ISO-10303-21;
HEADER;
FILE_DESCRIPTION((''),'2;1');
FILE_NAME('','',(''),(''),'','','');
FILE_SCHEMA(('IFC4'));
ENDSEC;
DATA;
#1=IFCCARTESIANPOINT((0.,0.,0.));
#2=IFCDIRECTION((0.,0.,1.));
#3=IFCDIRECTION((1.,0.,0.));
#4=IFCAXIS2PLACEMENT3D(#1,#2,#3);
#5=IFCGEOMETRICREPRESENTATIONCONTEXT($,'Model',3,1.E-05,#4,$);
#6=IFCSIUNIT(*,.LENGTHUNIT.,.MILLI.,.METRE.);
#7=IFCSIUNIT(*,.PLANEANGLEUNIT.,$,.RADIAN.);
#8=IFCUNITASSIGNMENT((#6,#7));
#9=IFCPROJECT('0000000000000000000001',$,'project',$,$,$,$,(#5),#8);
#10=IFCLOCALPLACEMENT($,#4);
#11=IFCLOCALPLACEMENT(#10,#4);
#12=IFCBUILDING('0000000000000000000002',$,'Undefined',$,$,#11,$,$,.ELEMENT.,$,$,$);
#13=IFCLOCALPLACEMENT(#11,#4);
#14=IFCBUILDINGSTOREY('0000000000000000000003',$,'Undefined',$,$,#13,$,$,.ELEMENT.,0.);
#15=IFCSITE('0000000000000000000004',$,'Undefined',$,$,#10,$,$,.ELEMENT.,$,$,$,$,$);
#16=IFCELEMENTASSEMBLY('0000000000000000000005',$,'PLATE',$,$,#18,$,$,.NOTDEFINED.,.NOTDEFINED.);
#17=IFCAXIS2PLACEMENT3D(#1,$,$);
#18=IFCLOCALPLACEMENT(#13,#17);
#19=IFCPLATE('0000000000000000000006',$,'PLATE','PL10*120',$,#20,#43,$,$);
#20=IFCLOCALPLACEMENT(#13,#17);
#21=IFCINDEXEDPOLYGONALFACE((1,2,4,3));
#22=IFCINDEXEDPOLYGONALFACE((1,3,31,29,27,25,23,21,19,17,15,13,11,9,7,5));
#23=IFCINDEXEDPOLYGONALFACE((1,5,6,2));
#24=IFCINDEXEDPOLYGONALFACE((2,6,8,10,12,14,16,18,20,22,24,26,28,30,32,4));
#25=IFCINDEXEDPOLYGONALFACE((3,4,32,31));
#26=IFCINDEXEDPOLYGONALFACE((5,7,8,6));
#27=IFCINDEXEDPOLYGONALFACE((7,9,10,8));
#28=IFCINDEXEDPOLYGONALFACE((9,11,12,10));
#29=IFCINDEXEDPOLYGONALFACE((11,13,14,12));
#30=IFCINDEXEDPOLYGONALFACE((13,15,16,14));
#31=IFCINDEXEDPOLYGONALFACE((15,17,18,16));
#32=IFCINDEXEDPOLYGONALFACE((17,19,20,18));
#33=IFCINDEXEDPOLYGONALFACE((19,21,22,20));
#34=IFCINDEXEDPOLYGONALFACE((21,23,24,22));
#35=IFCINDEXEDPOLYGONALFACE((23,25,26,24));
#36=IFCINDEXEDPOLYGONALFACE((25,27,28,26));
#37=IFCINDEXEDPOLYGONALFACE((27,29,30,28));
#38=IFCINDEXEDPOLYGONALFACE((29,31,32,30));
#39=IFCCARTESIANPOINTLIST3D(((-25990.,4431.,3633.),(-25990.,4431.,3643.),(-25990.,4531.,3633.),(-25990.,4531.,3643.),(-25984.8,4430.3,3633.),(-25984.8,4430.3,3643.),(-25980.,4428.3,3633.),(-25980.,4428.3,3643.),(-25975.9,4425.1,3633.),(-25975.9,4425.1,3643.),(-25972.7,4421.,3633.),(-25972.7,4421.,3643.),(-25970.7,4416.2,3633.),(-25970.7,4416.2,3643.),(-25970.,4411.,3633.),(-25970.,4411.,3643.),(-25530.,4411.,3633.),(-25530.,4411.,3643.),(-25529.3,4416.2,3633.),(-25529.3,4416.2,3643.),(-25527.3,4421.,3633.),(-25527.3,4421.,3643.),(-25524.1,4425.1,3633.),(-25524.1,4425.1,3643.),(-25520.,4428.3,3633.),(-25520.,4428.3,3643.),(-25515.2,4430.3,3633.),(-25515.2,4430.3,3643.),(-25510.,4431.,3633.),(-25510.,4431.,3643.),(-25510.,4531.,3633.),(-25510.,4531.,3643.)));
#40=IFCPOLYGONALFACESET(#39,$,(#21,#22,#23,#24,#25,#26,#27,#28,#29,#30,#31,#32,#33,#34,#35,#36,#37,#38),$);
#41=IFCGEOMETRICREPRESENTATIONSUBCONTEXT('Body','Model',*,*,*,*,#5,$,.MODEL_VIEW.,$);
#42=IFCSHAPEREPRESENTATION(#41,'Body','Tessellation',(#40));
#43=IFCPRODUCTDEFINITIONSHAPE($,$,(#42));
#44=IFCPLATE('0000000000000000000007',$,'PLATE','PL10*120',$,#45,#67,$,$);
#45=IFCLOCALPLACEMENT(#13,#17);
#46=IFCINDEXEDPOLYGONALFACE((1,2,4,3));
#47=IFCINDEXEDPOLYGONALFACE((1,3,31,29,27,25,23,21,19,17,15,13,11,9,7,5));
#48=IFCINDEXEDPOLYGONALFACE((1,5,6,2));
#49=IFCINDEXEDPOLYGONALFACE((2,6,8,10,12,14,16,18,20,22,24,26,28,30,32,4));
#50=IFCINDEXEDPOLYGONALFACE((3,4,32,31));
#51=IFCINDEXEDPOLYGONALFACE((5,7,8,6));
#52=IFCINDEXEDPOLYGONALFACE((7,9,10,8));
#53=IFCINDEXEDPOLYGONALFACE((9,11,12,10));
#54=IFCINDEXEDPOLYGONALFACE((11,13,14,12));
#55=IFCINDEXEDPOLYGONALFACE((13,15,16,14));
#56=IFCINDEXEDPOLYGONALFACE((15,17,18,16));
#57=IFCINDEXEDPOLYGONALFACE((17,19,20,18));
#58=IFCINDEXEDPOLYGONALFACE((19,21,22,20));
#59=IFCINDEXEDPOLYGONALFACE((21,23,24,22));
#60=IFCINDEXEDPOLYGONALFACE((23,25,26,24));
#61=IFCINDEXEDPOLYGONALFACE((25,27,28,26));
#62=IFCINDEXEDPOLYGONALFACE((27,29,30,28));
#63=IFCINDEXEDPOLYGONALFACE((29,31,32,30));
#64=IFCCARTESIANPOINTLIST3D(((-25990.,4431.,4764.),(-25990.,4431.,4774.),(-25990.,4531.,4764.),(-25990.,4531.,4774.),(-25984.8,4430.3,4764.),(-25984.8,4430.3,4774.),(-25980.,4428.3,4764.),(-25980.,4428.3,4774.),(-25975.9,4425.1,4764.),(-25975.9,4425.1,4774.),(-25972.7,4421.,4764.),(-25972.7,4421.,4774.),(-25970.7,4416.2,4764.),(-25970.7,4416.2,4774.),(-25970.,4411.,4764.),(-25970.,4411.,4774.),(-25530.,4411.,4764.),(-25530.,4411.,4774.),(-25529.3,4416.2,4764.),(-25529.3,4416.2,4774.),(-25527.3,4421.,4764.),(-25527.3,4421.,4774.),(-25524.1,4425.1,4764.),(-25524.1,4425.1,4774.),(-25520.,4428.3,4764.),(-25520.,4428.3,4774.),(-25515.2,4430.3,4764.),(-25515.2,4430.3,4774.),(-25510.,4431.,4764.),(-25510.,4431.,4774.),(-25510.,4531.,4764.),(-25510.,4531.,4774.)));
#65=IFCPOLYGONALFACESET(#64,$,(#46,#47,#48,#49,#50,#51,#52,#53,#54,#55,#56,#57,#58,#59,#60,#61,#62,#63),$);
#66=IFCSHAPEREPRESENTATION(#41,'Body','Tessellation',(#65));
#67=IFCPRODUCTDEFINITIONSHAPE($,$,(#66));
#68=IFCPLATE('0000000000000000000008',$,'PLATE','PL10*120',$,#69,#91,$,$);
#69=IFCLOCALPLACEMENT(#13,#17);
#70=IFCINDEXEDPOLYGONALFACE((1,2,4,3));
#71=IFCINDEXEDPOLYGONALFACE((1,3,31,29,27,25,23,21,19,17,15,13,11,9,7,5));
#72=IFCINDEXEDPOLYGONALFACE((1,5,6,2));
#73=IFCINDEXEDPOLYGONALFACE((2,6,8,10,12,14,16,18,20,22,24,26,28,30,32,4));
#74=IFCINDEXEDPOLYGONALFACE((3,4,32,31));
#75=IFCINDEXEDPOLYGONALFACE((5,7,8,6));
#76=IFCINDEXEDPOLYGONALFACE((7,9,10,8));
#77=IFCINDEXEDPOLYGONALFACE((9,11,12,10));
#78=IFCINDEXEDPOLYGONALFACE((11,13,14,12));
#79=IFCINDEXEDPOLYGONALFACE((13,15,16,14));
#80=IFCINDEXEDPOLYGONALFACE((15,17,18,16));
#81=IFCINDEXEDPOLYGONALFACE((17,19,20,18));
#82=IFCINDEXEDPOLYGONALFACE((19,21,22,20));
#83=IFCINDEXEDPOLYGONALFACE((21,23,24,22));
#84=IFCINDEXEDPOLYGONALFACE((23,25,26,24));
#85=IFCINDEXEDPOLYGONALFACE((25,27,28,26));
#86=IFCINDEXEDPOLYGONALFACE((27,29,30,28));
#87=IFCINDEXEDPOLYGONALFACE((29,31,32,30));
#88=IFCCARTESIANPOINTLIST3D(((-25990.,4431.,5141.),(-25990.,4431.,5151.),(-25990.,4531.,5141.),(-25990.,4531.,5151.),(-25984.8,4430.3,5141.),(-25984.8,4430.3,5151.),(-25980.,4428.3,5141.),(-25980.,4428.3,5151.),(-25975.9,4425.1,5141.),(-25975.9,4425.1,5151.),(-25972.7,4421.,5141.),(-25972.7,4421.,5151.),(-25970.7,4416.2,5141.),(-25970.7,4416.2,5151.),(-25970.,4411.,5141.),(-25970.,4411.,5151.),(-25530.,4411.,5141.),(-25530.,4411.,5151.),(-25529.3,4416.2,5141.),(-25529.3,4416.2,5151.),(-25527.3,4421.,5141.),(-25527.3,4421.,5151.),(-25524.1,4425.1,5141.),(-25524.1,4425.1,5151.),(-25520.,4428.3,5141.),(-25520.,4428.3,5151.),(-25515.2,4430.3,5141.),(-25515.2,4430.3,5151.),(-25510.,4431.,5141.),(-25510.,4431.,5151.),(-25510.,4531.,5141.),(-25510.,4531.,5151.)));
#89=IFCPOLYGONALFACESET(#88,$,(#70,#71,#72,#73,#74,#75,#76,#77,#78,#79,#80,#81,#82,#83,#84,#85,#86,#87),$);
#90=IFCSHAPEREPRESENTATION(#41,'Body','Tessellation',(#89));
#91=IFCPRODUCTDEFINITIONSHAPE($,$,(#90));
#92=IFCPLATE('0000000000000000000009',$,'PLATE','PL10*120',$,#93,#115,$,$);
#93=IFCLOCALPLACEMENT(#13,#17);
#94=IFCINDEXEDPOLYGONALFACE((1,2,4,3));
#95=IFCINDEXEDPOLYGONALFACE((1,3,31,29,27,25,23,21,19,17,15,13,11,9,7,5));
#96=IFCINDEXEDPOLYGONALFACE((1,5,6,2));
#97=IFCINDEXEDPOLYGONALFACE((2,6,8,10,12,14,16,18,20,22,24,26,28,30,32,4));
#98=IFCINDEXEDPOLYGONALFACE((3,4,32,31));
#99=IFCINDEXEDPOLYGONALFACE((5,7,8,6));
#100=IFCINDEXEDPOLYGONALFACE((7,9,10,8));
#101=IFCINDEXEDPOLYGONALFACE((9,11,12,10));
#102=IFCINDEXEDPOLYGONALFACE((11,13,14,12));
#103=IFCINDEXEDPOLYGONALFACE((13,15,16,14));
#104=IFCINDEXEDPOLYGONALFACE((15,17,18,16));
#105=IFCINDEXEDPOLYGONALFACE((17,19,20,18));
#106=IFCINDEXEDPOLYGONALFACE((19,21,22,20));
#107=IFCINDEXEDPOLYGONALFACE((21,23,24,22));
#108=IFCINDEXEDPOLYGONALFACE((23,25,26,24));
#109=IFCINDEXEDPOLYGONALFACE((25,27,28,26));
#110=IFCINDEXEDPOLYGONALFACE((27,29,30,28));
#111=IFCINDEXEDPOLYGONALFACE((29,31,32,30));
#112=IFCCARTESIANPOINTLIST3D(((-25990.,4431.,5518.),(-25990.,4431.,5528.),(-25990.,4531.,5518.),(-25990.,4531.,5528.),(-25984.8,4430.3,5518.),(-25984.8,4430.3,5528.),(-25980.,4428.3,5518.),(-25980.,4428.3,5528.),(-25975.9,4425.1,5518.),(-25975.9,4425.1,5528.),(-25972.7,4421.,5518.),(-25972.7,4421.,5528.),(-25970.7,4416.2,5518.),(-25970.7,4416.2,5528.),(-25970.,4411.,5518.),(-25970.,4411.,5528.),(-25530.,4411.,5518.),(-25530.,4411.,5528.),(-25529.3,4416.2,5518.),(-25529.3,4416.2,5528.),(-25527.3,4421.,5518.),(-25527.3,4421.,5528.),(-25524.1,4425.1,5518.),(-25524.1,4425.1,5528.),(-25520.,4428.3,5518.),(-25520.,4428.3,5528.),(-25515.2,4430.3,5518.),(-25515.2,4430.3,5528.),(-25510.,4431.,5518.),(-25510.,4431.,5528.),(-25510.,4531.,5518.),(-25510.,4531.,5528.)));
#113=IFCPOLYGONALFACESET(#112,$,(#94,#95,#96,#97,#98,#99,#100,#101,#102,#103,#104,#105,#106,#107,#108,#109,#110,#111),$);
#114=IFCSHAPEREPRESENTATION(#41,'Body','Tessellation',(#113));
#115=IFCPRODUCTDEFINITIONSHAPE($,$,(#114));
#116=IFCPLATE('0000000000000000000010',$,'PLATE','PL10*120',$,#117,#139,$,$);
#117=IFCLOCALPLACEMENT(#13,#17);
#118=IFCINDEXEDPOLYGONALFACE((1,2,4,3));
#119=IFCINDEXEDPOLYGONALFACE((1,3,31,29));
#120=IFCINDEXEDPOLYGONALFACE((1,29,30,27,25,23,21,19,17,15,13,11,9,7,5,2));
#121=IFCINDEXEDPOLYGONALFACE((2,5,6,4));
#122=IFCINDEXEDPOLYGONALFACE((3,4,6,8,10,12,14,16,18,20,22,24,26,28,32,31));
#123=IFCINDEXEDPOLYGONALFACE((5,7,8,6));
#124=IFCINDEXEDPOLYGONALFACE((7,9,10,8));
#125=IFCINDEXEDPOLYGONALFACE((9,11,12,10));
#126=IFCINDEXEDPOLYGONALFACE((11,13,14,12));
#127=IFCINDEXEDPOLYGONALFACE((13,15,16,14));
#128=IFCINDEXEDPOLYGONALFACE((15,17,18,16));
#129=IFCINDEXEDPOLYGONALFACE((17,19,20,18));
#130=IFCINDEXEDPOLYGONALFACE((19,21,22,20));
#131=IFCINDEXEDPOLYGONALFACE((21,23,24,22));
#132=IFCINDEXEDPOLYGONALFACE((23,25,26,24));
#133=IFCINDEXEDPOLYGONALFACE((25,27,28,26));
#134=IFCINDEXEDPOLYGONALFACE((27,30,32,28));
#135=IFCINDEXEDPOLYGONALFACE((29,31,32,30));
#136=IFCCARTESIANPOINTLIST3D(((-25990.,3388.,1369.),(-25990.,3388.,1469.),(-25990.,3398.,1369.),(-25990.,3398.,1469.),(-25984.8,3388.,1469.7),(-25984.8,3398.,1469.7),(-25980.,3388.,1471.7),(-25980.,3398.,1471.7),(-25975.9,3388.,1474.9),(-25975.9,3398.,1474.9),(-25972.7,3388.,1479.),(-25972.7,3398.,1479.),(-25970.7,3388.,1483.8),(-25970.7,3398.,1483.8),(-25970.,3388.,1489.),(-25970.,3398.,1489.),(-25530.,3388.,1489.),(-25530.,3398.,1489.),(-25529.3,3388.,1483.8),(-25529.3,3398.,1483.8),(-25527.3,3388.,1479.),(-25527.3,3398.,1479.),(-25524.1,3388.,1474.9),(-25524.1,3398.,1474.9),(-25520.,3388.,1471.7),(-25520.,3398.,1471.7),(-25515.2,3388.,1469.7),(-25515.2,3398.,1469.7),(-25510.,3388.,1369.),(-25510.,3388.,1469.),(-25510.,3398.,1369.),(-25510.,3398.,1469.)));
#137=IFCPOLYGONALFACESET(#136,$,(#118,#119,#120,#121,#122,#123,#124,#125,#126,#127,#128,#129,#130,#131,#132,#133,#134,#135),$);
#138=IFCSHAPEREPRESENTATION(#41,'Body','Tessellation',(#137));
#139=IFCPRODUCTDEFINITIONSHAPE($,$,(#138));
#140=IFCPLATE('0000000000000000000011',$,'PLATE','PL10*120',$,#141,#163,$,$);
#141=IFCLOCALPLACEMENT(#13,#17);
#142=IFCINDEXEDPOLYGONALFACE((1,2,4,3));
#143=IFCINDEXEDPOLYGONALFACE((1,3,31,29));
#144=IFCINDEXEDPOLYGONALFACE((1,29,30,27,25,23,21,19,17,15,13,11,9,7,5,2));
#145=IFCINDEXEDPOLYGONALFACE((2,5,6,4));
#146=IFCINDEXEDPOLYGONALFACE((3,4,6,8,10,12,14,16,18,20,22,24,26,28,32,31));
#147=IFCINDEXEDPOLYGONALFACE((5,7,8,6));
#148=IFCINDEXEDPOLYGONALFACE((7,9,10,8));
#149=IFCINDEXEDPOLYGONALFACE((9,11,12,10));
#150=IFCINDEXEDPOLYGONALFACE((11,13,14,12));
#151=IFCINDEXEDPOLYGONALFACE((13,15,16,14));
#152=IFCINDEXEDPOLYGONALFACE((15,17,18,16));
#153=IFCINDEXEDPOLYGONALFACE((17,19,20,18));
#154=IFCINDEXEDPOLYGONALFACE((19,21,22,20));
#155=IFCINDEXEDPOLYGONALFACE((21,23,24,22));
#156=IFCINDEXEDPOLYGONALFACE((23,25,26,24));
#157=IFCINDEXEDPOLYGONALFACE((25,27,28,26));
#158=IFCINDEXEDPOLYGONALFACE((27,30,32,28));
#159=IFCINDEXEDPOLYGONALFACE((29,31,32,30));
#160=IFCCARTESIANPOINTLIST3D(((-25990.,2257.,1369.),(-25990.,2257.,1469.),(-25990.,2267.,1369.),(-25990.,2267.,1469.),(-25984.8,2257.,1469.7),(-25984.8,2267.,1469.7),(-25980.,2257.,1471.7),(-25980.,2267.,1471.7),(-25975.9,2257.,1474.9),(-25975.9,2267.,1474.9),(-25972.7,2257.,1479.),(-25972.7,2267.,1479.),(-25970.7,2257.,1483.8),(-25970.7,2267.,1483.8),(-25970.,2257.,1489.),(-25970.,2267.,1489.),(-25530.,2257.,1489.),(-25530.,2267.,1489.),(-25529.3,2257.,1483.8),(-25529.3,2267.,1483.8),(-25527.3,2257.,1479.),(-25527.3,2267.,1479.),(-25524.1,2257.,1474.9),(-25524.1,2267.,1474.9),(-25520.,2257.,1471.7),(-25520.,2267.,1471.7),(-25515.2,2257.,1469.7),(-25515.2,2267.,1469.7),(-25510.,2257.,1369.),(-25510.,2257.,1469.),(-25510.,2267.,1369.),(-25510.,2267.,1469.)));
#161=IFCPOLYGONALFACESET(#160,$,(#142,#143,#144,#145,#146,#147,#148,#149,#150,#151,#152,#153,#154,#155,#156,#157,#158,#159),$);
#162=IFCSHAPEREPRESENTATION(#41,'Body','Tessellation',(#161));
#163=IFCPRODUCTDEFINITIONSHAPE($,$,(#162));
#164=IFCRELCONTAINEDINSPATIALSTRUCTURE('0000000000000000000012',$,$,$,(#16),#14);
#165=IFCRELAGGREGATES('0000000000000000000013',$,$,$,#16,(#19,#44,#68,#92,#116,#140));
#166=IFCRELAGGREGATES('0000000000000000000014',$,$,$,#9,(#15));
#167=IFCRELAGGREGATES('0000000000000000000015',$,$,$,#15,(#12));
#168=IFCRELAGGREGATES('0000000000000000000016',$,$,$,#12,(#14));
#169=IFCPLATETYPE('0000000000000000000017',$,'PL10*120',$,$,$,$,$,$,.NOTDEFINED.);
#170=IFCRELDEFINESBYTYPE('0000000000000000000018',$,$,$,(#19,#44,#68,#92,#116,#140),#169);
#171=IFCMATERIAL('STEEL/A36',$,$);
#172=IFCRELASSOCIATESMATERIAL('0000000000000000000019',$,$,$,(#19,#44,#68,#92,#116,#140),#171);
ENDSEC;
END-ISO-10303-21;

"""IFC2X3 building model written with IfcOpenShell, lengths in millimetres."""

from ifc_helpers import new_model, si_unit, frame, frame_2d, origin_with_axes, place, context, subcontext, project, spatial, polyline, circle_curve, parameter, trimmed, segment, composite_curve, outline, extrude, material, type_object, element, aggregate, save


model = new_model("IFC2X3")

# Units and contexts
model_context = context("Model", 3, precision=1e-05, world=origin_with_axes())
body_context = subcontext(model_context, "Body", "Model", "MODEL_VIEW")
ifc_project = project(units=[si_unit("LENGTHUNIT", "METRE", prefix="MILLI"), si_unit("PLANEANGLEUNIT", "RADIAN")], contexts=[model_context])

# Site, building, storey
site_placement = place(None, origin_with_axes())
site = spatial("IfcSite", under=ifc_project, at=site_placement, Name="Undefined", CompositionType="ELEMENT")
building_placement = place(site_placement, origin_with_axes())
building = spatial("IfcBuilding", under=site, at=building_placement, Name="Undefined", CompositionType="ELEMENT")
storey_placement = place(building_placement, origin_with_axes())
storey = spatial("IfcBuildingStorey", under=building, at=storey_placement, Name="Undefined", CompositionType="ELEMENT", Elevation=0.0)

# Element assembly, plates
assembly_1_placement = place(storey_placement, origin_with_axes())
assembly_1 = element("IfcElementAssembly", 1, at=assembly_1_placement, inside=storey, Name="PLATE", AssemblyPlace="NOTDEFINED", PredefinedType="NOTDEFINED")
ifc_material_1 = material(Name="STEEL/A36")
plate_type_1 = type_object("IfcPlateType", Name="PL10*120", PredefinedType="NOTDEFINED")
plate_1_placement = place(assembly_1_placement, frame((-25510.0, 4531.0, 3638.0), z_axis=(0.0, 0.0, 1.0), x_axis=(-1.0, 0.0, 0.0)))
plate_1 = element("IfcPlate", 2, at=plate_1_placement, type_object=plate_type_1, material=ifc_material_1, Name="PLATE", Description="PL10*120", context=body_context, shape_type="SweptSolid", body=[
    extrude(outline(composite_curve([segment(polyline([(0.0, 0.0), (480.0, 0.0), (480.0, 100.0)]), True, "CONTINUOUS"), segment(trimmed(circle_curve(frame_2d((480.0, 120.0), x_axis=(-0.000015, -1.0)), 20.0), [parameter(0.0)], [parameter(4.712402)], False, "PARAMETER"), True, "CONTINUOUS"), segment(polyline([(460.0, 120.0), (20.0, 120.0)]), True, "CONTINUOUS"), segment(trimmed(circle_curve(frame_2d((0.0, 120.0), x_axis=(1.0, -0.000002)), 20.0), [parameter(0.0)], [parameter(4.712393)], False, "PARAMETER"), True, "CONTINUOUS"), segment(polyline([(0.0, 100.0), (0.0, 0.0)]), True, "CONTINUOUS")], self_intersect=True)), frame((0.0, 0.0, -5.0), z_axis=(0.0, 0.0, 1.0), x_axis=(1.0, 0.0, 0.0)), (0.0, 0.0, 1.0), 10.0),
])
plate_2_placement = place(assembly_1_placement, frame((-25510.0, 4531.0, 4769.0), z_axis=(0.0, 0.0, 1.0), x_axis=(-1.0, 0.0, 0.0)))
plate_2 = element("IfcPlate", 3, at=plate_2_placement, type_object=plate_type_1, material=ifc_material_1, Name="PLATE", Description="PL10*120", context=body_context, shape_type="SweptSolid", body=[
    extrude(outline(composite_curve([segment(polyline([(0.0, 0.0), (480.0, 0.0), (480.0, 100.0)]), True, "CONTINUOUS"), segment(trimmed(circle_curve(frame_2d((480.0, 120.0), x_axis=(-0.000015, -1.0)), 20.0), [parameter(0.0)], [parameter(4.712402)], False, "PARAMETER"), True, "CONTINUOUS"), segment(polyline([(460.0, 120.0), (20.0, 120.0)]), True, "CONTINUOUS"), segment(trimmed(circle_curve(frame_2d((0.0, 120.0), x_axis=(1.0, -0.000002)), 20.0), [parameter(0.0)], [parameter(4.712393)], False, "PARAMETER"), True, "CONTINUOUS"), segment(polyline([(0.0, 100.0), (0.0, 0.0)]), True, "CONTINUOUS")], self_intersect=True)), frame((0.0, 0.0, -5.0), z_axis=(0.0, 0.0, 1.0), x_axis=(1.0, 0.0, 0.0)), (0.0, 0.0, 1.0), 10.0),
])
plate_3_placement = place(assembly_1_placement, frame((-25510.0, 4531.0, 5146.0), z_axis=(0.0, 0.0, 1.0), x_axis=(-1.0, 0.0, 0.0)))
plate_3 = element("IfcPlate", 4, at=plate_3_placement, type_object=plate_type_1, material=ifc_material_1, Name="PLATE", Description="PL10*120", context=body_context, shape_type="SweptSolid", body=[
    extrude(outline(composite_curve([segment(polyline([(0.0, 0.0), (480.0, 0.0), (480.0, 100.0)]), True, "CONTINUOUS"), segment(trimmed(circle_curve(frame_2d((480.0, 120.0), x_axis=(-0.000015, -1.0)), 20.0), [parameter(0.0)], [parameter(4.712402)], False, "PARAMETER"), True, "CONTINUOUS"), segment(polyline([(460.0, 120.0), (20.0, 120.0)]), True, "CONTINUOUS"), segment(trimmed(circle_curve(frame_2d((0.0, 120.0), x_axis=(1.0, -0.000002)), 20.0), [parameter(0.0)], [parameter(4.712393)], False, "PARAMETER"), True, "CONTINUOUS"), segment(polyline([(0.0, 100.0), (0.0, 0.0)]), True, "CONTINUOUS")], self_intersect=True)), frame((0.0, 0.0, -5.0), z_axis=(0.0, 0.0, 1.0), x_axis=(1.0, 0.0, 0.0)), (0.0, 0.0, 1.0), 10.0),
])
plate_4_placement = place(assembly_1_placement, frame((-25510.0, 4531.0, 5523.0), z_axis=(0.0, 0.0, 1.0), x_axis=(-1.0, 0.0, 0.0)))
plate_4 = element("IfcPlate", 5, at=plate_4_placement, type_object=plate_type_1, material=ifc_material_1, Name="PLATE", Description="PL10*120", context=body_context, shape_type="SweptSolid", body=[
    extrude(outline(composite_curve([segment(polyline([(0.0, 0.0), (480.0, 0.0), (480.0, 100.0)]), True, "CONTINUOUS"), segment(trimmed(circle_curve(frame_2d((480.0, 120.0), x_axis=(-0.000015, -1.0)), 20.0), [parameter(0.0)], [parameter(4.712402)], False, "PARAMETER"), True, "CONTINUOUS"), segment(polyline([(460.0, 120.0), (20.0, 120.0)]), True, "CONTINUOUS"), segment(trimmed(circle_curve(frame_2d((0.0, 120.0), x_axis=(1.0, -0.000002)), 20.0), [parameter(0.0)], [parameter(4.712393)], False, "PARAMETER"), True, "CONTINUOUS"), segment(polyline([(0.0, 100.0), (0.0, 0.0)]), True, "CONTINUOUS")], self_intersect=True)), frame((0.0, 0.0, -5.0), z_axis=(0.0, 0.0, 1.0), x_axis=(1.0, 0.0, 0.0)), (0.0, 0.0, 1.0), 10.0),
])
plate_5_placement = place(assembly_1_placement, frame((-25510.0, 3393.0, 1369.0), z_axis=(0.0, 1.0, 0.0), x_axis=(-1.0, 0.0, 0.0)))
plate_5 = element("IfcPlate", 6, at=plate_5_placement, type_object=plate_type_1, material=ifc_material_1, Name="PLATE", Description="PL10*120", context=body_context, shape_type="SweptSolid", body=[
    extrude(outline(composite_curve([segment(polyline([(0.0, 0.0), (480.0, 0.0), (480.0, 100.0)]), True, "CONTINUOUS"), segment(trimmed(circle_curve(frame_2d((480.0, 120.0), x_axis=(-0.000015, -1.0)), 20.0), [parameter(0.0)], [parameter(4.712402)], False, "PARAMETER"), True, "CONTINUOUS"), segment(polyline([(460.0, 120.0), (20.0, 120.0)]), True, "CONTINUOUS"), segment(trimmed(circle_curve(frame_2d((0.0, 120.0), x_axis=(1.0, -0.000002)), 20.0), [parameter(0.0)], [parameter(4.712393)], False, "PARAMETER"), True, "CONTINUOUS"), segment(polyline([(0.0, 100.0), (0.0, 0.0)]), True, "CONTINUOUS")], self_intersect=True)), frame((0.0, 0.0, -5.0), z_axis=(0.0, 0.0, 1.0), x_axis=(1.0, 0.0, 0.0)), (0.0, 0.0, 1.0), 10.0),
])
plate_6_placement = place(assembly_1_placement, frame((-25510.0, 2262.0, 1369.0), z_axis=(0.0, 1.0, 0.0), x_axis=(-1.0, 0.0, 0.0)))
plate_6 = element("IfcPlate", 7, at=plate_6_placement, type_object=plate_type_1, material=ifc_material_1, Name="PLATE", Description="PL10*120", context=body_context, shape_type="SweptSolid", body=[
    extrude(outline(composite_curve([segment(polyline([(0.0, 0.0), (480.0, 0.0), (480.0, 100.0)]), True, "CONTINUOUS"), segment(trimmed(circle_curve(frame_2d((480.0, 120.0), x_axis=(-0.000015, -1.0)), 20.0), [parameter(0.0)], [parameter(4.712402)], False, "PARAMETER"), True, "CONTINUOUS"), segment(polyline([(460.0, 120.0), (20.0, 120.0)]), True, "CONTINUOUS"), segment(trimmed(circle_curve(frame_2d((0.0, 120.0), x_axis=(1.0, -0.000002)), 20.0), [parameter(0.0)], [parameter(4.712393)], False, "PARAMETER"), True, "CONTINUOUS"), segment(polyline([(0.0, 100.0), (0.0, 0.0)]), True, "CONTINUOUS")], self_intersect=True)), frame((0.0, 0.0, -5.0), z_axis=(0.0, 0.0, 1.0), x_axis=(1.0, 0.0, 0.0)), (0.0, 0.0, 1.0), 10.0),
])

aggregate(assembly_1, [plate_1, plate_2, plate_3, plate_4, plate_5, plate_6])

save(model, "model.ifc")
